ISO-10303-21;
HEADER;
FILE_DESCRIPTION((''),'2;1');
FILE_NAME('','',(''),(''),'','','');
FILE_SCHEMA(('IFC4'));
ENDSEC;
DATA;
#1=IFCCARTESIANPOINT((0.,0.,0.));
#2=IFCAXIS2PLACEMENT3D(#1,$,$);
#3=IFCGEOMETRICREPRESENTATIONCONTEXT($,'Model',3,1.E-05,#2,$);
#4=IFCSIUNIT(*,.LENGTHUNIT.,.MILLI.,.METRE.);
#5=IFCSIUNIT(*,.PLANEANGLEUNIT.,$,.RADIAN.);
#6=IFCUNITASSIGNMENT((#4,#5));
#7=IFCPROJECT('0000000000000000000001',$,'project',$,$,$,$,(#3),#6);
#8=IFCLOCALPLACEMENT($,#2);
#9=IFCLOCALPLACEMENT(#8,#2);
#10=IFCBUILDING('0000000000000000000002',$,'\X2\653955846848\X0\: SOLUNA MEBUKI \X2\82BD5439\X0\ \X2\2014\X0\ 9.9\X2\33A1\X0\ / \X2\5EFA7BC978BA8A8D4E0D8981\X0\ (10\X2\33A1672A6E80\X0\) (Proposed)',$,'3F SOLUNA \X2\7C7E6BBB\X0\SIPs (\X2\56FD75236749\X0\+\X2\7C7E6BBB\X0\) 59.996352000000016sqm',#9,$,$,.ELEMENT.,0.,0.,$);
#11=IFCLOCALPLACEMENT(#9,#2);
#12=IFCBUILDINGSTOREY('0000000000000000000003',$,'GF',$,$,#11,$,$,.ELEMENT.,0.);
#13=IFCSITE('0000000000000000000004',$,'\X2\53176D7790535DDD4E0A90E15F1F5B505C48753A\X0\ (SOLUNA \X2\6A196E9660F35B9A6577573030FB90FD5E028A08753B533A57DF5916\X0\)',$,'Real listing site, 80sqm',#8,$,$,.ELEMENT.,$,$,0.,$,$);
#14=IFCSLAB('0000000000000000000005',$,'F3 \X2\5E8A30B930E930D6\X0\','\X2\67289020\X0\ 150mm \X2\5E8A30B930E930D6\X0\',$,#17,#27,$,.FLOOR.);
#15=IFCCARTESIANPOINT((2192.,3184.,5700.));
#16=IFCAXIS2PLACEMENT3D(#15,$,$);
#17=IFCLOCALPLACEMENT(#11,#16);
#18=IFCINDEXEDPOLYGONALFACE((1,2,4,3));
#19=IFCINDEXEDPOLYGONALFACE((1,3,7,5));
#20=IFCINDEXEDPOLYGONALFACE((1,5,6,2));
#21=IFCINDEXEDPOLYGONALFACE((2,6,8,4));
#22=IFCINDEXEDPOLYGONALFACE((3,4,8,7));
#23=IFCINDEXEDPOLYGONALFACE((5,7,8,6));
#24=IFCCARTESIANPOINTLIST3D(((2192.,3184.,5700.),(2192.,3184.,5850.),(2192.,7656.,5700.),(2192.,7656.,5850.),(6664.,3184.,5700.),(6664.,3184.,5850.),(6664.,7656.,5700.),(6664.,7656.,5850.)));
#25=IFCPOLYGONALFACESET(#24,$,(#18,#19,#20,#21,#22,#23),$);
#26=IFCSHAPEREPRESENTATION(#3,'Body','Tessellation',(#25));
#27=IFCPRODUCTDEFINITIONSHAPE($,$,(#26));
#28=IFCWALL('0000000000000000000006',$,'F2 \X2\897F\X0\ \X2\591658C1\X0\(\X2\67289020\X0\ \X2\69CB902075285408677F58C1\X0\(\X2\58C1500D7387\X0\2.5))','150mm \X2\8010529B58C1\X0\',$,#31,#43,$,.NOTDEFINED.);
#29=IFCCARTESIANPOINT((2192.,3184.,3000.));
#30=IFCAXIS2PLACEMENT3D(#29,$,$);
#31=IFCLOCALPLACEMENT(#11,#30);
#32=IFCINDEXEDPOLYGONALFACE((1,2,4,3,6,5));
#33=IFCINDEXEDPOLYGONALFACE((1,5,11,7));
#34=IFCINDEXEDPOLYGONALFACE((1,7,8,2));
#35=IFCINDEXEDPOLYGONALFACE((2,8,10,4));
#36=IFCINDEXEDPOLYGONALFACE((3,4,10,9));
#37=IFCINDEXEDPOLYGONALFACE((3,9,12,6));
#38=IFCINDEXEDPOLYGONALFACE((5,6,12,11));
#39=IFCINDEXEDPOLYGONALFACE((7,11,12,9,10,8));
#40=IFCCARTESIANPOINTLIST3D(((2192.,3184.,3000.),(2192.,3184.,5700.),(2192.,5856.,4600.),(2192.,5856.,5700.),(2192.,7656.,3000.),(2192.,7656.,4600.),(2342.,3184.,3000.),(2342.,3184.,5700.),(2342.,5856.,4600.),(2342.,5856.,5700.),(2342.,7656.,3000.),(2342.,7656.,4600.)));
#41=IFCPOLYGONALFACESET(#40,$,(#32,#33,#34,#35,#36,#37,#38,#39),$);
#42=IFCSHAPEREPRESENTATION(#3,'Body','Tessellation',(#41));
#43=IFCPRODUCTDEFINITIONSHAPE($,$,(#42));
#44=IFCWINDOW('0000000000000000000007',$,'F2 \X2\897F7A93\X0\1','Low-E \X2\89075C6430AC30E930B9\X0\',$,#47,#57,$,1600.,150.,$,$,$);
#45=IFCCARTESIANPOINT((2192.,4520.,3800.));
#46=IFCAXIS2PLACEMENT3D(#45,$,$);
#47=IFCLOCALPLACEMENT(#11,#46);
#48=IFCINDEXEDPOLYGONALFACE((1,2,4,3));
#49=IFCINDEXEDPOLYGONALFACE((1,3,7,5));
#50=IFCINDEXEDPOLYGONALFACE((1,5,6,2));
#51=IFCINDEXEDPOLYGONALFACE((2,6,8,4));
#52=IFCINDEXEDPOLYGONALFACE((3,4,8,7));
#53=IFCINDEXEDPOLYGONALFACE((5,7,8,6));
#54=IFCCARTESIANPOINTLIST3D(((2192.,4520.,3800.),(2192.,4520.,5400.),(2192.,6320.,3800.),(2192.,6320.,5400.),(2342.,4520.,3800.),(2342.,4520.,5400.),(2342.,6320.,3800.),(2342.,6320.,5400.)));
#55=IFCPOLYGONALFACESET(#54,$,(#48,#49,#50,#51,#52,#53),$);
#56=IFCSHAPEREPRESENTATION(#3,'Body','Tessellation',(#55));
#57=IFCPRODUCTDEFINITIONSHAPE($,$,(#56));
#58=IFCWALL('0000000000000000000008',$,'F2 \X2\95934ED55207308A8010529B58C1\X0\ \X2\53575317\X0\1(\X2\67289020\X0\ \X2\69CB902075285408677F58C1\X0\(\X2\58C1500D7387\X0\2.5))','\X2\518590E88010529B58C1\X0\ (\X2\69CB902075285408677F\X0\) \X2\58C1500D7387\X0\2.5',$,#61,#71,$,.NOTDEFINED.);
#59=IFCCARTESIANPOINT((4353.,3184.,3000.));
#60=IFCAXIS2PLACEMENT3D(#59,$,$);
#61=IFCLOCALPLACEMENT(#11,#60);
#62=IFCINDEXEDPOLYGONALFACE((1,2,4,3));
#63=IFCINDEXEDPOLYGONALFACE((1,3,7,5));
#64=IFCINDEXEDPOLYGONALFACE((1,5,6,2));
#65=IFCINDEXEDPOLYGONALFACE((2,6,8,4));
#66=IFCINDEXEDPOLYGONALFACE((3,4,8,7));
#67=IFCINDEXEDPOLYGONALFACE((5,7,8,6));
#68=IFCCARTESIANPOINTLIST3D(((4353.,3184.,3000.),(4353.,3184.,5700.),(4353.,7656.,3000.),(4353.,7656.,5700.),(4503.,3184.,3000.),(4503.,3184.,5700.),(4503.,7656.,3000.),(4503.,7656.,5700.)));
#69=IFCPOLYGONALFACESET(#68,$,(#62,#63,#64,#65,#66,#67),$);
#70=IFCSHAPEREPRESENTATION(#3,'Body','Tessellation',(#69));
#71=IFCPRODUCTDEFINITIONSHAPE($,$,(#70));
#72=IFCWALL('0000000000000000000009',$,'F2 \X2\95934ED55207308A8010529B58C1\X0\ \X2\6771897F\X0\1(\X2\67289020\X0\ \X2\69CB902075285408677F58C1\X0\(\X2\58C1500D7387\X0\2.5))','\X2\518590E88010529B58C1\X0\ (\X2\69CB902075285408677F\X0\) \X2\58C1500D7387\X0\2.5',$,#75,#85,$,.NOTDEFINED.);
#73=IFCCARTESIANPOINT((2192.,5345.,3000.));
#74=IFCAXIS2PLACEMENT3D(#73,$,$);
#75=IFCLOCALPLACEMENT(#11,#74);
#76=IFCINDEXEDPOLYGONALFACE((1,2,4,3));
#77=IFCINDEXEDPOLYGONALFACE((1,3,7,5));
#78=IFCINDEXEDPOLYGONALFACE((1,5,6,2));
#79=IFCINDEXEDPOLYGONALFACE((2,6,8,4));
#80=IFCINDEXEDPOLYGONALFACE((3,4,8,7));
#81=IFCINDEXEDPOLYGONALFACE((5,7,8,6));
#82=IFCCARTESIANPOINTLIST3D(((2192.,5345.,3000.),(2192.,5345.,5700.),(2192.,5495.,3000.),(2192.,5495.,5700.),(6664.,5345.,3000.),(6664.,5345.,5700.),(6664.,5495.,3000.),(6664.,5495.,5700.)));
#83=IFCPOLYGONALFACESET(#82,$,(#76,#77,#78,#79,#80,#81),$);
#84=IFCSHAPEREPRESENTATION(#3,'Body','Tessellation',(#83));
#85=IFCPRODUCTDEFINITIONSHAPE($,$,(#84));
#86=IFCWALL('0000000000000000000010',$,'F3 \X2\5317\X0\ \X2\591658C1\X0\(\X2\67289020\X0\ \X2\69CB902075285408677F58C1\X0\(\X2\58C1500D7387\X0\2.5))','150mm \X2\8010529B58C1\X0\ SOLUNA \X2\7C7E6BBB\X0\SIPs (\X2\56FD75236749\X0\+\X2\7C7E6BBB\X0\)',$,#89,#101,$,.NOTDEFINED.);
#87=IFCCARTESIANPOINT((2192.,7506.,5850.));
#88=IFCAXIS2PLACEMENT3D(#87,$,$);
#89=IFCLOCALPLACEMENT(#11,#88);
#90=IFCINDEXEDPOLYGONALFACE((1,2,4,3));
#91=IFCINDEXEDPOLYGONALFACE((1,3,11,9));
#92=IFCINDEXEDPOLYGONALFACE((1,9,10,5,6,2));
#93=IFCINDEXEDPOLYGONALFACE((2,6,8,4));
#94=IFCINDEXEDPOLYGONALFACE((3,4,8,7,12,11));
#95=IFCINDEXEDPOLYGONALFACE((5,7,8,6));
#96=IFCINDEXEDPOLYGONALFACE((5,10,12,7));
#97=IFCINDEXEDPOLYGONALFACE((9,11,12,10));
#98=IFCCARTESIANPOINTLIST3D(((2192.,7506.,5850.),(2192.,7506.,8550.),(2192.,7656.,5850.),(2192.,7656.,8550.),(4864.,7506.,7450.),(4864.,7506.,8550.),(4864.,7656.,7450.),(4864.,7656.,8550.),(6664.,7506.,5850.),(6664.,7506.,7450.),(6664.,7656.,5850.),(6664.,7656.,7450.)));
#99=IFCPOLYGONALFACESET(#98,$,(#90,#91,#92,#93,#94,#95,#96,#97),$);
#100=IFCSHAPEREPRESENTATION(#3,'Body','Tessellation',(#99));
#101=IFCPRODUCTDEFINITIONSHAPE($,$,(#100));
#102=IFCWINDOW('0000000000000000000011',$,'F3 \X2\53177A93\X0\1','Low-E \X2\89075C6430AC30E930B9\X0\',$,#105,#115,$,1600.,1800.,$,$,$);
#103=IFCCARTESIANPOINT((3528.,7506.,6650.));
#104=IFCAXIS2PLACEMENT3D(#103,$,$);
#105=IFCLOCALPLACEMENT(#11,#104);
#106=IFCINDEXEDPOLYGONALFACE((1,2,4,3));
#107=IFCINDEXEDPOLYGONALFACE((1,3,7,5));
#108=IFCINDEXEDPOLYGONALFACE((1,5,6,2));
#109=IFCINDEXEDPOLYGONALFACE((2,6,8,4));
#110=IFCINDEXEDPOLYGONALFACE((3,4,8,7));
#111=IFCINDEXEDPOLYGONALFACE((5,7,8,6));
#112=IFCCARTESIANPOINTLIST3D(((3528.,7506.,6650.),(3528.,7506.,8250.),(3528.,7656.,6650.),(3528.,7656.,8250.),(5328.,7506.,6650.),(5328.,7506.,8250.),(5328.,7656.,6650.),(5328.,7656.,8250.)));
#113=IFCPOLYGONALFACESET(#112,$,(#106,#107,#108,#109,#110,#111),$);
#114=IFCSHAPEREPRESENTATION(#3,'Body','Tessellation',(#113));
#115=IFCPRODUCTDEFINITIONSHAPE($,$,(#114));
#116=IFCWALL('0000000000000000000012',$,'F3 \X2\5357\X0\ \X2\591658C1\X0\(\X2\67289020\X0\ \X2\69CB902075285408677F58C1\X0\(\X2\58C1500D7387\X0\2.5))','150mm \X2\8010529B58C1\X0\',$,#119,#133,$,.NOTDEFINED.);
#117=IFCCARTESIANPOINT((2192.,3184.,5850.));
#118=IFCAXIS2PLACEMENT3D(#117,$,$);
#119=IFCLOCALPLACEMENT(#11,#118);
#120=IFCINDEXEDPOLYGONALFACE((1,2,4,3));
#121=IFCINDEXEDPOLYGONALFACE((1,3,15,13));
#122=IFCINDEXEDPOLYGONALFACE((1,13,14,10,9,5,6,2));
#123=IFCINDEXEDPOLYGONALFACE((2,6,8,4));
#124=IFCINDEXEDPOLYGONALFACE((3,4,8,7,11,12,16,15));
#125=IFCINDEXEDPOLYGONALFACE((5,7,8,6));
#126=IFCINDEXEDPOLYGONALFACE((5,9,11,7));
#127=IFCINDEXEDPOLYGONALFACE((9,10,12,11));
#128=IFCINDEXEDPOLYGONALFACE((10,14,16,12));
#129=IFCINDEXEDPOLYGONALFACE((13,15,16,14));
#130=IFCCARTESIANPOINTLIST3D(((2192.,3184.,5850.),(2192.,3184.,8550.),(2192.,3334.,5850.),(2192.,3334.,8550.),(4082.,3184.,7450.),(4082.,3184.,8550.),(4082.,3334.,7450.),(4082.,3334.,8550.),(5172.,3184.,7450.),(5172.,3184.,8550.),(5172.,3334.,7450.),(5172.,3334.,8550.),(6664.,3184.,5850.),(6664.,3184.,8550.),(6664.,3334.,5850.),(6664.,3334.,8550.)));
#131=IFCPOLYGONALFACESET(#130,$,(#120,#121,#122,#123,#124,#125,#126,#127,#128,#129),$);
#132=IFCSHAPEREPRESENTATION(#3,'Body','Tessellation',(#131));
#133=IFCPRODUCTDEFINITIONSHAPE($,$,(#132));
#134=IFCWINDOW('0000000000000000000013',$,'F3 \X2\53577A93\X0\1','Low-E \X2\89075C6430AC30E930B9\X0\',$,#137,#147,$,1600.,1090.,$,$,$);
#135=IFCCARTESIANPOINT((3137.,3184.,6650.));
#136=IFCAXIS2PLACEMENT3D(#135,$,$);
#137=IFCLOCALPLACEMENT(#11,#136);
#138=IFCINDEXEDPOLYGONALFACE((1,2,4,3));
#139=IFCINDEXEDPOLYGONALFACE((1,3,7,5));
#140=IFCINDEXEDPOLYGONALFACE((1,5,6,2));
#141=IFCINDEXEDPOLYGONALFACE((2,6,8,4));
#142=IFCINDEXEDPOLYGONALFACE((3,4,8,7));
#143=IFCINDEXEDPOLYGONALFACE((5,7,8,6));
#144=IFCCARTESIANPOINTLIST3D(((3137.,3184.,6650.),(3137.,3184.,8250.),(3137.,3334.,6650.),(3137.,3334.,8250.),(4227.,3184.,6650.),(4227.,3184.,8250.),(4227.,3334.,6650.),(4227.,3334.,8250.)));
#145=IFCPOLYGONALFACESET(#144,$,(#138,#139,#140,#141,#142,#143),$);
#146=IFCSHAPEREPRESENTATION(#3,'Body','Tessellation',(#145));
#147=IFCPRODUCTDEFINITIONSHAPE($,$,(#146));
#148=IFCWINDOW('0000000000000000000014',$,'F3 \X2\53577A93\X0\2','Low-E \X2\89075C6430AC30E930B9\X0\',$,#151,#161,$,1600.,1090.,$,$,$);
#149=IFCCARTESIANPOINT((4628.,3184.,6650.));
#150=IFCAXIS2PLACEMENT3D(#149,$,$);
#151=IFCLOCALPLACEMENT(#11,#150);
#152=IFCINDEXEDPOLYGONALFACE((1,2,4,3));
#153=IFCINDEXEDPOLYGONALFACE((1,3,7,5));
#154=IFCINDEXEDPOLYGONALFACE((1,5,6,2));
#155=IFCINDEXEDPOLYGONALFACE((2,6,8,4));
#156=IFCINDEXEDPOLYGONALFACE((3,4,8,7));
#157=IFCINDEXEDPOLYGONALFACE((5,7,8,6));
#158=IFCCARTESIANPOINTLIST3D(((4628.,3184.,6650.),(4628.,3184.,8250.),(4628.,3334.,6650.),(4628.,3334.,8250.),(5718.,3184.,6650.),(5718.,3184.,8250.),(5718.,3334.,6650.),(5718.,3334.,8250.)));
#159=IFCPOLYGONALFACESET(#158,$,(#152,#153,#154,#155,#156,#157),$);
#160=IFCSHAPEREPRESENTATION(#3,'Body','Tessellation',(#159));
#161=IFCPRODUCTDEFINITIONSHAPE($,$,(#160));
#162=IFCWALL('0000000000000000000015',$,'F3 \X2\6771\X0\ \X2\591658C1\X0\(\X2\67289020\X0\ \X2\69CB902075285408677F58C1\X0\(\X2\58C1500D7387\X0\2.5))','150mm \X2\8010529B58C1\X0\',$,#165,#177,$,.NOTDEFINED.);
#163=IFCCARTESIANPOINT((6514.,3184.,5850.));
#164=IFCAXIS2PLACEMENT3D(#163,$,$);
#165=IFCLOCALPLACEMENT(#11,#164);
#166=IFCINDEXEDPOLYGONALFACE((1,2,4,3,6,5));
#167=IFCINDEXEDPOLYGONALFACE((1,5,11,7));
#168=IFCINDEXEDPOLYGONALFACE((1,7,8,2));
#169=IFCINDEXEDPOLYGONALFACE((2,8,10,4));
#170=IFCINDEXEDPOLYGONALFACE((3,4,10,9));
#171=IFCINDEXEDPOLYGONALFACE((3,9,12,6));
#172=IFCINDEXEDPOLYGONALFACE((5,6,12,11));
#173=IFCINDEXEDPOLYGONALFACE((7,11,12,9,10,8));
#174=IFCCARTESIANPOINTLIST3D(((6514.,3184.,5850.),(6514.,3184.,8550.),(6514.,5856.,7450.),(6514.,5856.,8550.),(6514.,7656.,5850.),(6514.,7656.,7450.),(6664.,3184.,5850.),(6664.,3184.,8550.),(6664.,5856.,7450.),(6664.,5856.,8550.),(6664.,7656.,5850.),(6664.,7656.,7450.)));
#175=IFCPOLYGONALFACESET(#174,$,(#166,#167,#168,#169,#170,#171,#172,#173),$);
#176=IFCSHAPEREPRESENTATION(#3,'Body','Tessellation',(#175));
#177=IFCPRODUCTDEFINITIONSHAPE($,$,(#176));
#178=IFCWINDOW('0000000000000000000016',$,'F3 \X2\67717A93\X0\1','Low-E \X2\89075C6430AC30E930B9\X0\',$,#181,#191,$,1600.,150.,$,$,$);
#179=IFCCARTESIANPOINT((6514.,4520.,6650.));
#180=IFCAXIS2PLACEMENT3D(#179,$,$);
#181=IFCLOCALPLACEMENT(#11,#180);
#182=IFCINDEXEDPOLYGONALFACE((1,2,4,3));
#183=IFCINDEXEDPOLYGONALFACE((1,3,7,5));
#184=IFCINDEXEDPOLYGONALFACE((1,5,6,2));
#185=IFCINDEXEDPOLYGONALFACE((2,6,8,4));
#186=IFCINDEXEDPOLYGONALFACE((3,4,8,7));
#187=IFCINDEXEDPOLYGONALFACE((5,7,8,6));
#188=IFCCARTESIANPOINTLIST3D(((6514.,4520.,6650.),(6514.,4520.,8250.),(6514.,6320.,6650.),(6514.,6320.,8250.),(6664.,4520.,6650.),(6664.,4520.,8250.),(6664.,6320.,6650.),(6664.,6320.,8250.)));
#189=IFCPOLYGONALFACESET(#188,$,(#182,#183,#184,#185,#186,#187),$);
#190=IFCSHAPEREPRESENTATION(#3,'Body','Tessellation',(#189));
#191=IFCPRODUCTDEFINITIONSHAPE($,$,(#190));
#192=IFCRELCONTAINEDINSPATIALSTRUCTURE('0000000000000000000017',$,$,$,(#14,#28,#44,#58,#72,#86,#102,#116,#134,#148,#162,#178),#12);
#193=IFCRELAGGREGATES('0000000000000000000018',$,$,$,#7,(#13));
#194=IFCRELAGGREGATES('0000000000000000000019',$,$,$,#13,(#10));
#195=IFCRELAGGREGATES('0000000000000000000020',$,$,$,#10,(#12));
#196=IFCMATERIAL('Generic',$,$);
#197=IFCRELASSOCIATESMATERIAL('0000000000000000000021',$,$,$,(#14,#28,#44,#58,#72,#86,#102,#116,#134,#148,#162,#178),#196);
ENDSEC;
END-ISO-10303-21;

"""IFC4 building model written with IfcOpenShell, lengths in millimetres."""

from ifc_helpers import new_model, si_unit, frame, frame_2d, origin, place, context, project, spatial, rectangle, extrude, material, element, fill, save


model = new_model("IFC4")

# Units and contexts
model_context = context("Model", 3, precision=1e-05, world=origin())
ifc_project = project(units=[si_unit("LENGTHUNIT", "METRE", prefix="MILLI"), si_unit("PLANEANGLEUNIT", "RADIAN")], contexts=[model_context])

# Site, building, storey
site_placement = place(None, origin())
site = spatial("IfcSite", under=ifc_project, at=site_placement, Name="北海道川上郡弟子屈町 (SOLUNA 標準想定敷地・都市計画区域外)", ObjectType="Real listing site, 80sqm", CompositionType="ELEMENT", RefElevation=0.0)
building_placement = place(site_placement, origin())
building = spatial("IfcBuilding", under=site, at=building_placement, Name="改善案: SOLUNA MEBUKI 芽吹 — 9.9㎡ / 建築確認不要 (10㎡未満) (Proposed)", ObjectType="3F SOLUNA 籾殻SIPs (国産杉+籾殻) 59.996352000000016sqm", CompositionType="ELEMENT", ElevationOfRefHeight=0.0, ElevationOfTerrain=0.0)
storey_placement = place(building_placement, origin())
storey = spatial("IfcBuildingStorey", under=building, at=storey_placement, Name="GF", CompositionType="ELEMENT", Elevation=0.0)

# Slab
ifc_material_1 = material(Name="Generic")
slab_placement = place(storey_placement, frame((2192.0, 3184.0, 5700.0)))
element("IfcSlab", 1, at=slab_placement, inside=storey, material=ifc_material_1, Name="F3 床スラブ", Description="木造 150mm 床スラブ", PredefinedType="FLOOR", context=model_context, shape_type="SweptSolid", body=[
    extrude(rectangle(XDim=4472.0, YDim=4472.0, at=frame_2d((2236.0, 2236.0))), frame((2192.0, 3184.0, 5700.0)), (0.0, 0.0, 1.0), 150.0),
])

# Wall, opening, window
wall_1_placement = place(storey_placement, frame((2192.0, 3184.0, 3000.0)))
wall_1 = element("IfcWall", 2, at=wall_1_placement, inside=storey, material=ifc_material_1, Name="F2 西 外壁(木造 構造用合板壁(壁倍率2.5))", Description="150mm 耐力壁", PredefinedType="NOTDEFINED", context=model_context, shape_type="SweptSolid", body=[
    extrude(rectangle(XDim=150.0, YDim=4472.0, at=frame_2d((75.0, 2236.0))), frame((2192.0, 3184.0, 3000.0)), (0.0, 0.0, 1.0), 2700.0),
])
opening_1_placement = place(storey_placement, frame((2192.0, 4520.0, 3800.0)))
opening_1 = element("IfcOpeningElement", 3, at=opening_1_placement, cuts=wall_1, PredefinedType="NOTDEFINED", context=model_context, shape_type="SweptSolid", body=[
    extrude(rectangle(XDim=150.0, YDim=1800.0, at=frame_2d((75.0, 900.0))), frame((2192.0, 4520.0, 3800.0)), (0.0, 0.0, 1.0), 1600.0),
])
window_1_placement = place(storey_placement, frame((2192.0, 4520.0, 3800.0)))
window_1 = element("IfcWindow", 4, at=window_1_placement, inside=storey, material=ifc_material_1, Name="F2 西窓1", Description="Low-E 複層ガラス", OverallHeight=1600.0, OverallWidth=150.0, context=model_context, shape_type="SweptSolid", body=[
    extrude(rectangle(XDim=150.0, YDim=1800.0, at=frame_2d((75.0, 900.0))), frame((2192.0, 4520.0, 3800.0)), (0.0, 0.0, 1.0), 1600.0),
])
fill(opening_1, window_1)

# Walls
wall_2_placement = place(storey_placement, frame((4353.0, 3184.0, 3000.0)))
element("IfcWall", 5, at=wall_2_placement, inside=storey, material=ifc_material_1, Name="F2 間仕切り耐力壁 南北1(木造 構造用合板壁(壁倍率2.5))", Description="内部耐力壁 (構造用合板) 壁倍率2.5", PredefinedType="NOTDEFINED", context=model_context, shape_type="SweptSolid", body=[
    extrude(rectangle(XDim=150.0, YDim=4472.0, at=frame_2d((75.0, 2236.0))), frame((4353.0, 3184.0, 3000.0)), (0.0, 0.0, 1.0), 2700.0),
])
wall_3_placement = place(storey_placement, frame((2192.0, 5345.0, 3000.0)))
element("IfcWall", 6, at=wall_3_placement, inside=storey, material=ifc_material_1, Name="F2 間仕切り耐力壁 東西1(木造 構造用合板壁(壁倍率2.5))", Description="内部耐力壁 (構造用合板) 壁倍率2.5", PredefinedType="NOTDEFINED", context=model_context, shape_type="SweptSolid", body=[
    extrude(rectangle(XDim=4472.0, YDim=150.0, at=frame_2d((2236.0, 75.0))), frame((2192.0, 5345.0, 3000.0)), (0.0, 0.0, 1.0), 2700.0),
])

# Wall, opening, window
wall_4_placement = place(storey_placement, frame((2192.0, 7506.0, 5850.0)))
wall_4 = element("IfcWall", 7, at=wall_4_placement, inside=storey, material=ifc_material_1, Name="F3 北 外壁(木造 構造用合板壁(壁倍率2.5))", Description="150mm 耐力壁 SOLUNA 籾殻SIPs (国産杉+籾殻)", PredefinedType="NOTDEFINED", context=model_context, shape_type="SweptSolid", body=[
    extrude(rectangle(XDim=4472.0, YDim=150.0, at=frame_2d((2236.0, 75.0))), frame((2192.0, 7506.0, 5850.0)), (0.0, 0.0, 1.0), 2700.0),
])
opening_2_placement = place(storey_placement, frame((3528.0, 7506.0, 6650.0)))
opening_2 = element("IfcOpeningElement", 8, at=opening_2_placement, cuts=wall_4, PredefinedType="NOTDEFINED", context=model_context, shape_type="SweptSolid", body=[
    extrude(rectangle(XDim=1800.0, YDim=150.0, at=frame_2d((900.0, 75.0))), frame((3528.0, 7506.0, 6650.0)), (0.0, 0.0, 1.0), 1600.0),
])
window_2_placement = place(storey_placement, frame((3528.0, 7506.0, 6650.0)))
window_2 = element("IfcWindow", 9, at=window_2_placement, inside=storey, material=ifc_material_1, Name="F3 北窓1", Description="Low-E 複層ガラス", OverallHeight=1600.0, OverallWidth=1800.0, context=model_context, shape_type="SweptSolid", body=[
    extrude(rectangle(XDim=1800.0, YDim=150.0, at=frame_2d((900.0, 75.0))), frame((3528.0, 7506.0, 6650.0)), (0.0, 0.0, 1.0), 1600.0),
])
fill(opening_2, window_2)

# Wall, openings, windows
wall_5_placement = place(storey_placement, frame((2192.0, 3184.0, 5850.0)))
wall_5 = element("IfcWall", 10, at=wall_5_placement, inside=storey, material=ifc_material_1, Name="F3 南 外壁(木造 構造用合板壁(壁倍率2.5))", Description="150mm 耐力壁", PredefinedType="NOTDEFINED", context=model_context, shape_type="SweptSolid", body=[
    extrude(rectangle(XDim=4472.0, YDim=150.0, at=frame_2d((2236.0, 75.0))), frame((2192.0, 3184.0, 5850.0)), (0.0, 0.0, 1.0), 2700.0),
])
opening_3_placement = place(storey_placement, frame((3137.0, 3184.0, 6650.0)))
opening_3 = element("IfcOpeningElement", 11, at=opening_3_placement, cuts=wall_5, PredefinedType="NOTDEFINED", context=model_context, shape_type="SweptSolid", body=[
    extrude(rectangle(XDim=1090.0, YDim=150.0, at=frame_2d((545.0, 75.0))), frame((3137.0, 3184.0, 6650.0)), (0.0, 0.0, 1.0), 1600.0),
])
opening_4_placement = place(storey_placement, frame((4628.0, 3184.0, 6650.0)))
opening_4 = element("IfcOpeningElement", 12, at=opening_4_placement, cuts=wall_5, PredefinedType="NOTDEFINED", context=model_context, shape_type="SweptSolid", body=[
    extrude(rectangle(XDim=1090.0, YDim=150.0, at=frame_2d((545.0, 75.0))), frame((4628.0, 3184.0, 6650.0)), (0.0, 0.0, 1.0), 1600.0),
])
window_3_placement = place(storey_placement, frame((3137.0, 3184.0, 6650.0)))
window_3 = element("IfcWindow", 13, at=window_3_placement, inside=storey, material=ifc_material_1, Name="F3 南窓1", Description="Low-E 複層ガラス", OverallHeight=1600.0, OverallWidth=1090.0, context=model_context, shape_type="SweptSolid", body=[
    extrude(rectangle(XDim=1090.0, YDim=150.0, at=frame_2d((545.0, 75.0))), frame((3137.0, 3184.0, 6650.0)), (0.0, 0.0, 1.0), 1600.0),
])
fill(opening_3, window_3)
window_4_placement = place(storey_placement, frame((4628.0, 3184.0, 6650.0)))
window_4 = element("IfcWindow", 14, at=window_4_placement, inside=storey, material=ifc_material_1, Name="F3 南窓2", Description="Low-E 複層ガラス", OverallHeight=1600.0, OverallWidth=1090.0, context=model_context, shape_type="SweptSolid", body=[
    extrude(rectangle(XDim=1090.0, YDim=150.0, at=frame_2d((545.0, 75.0))), frame((4628.0, 3184.0, 6650.0)), (0.0, 0.0, 1.0), 1600.0),
])
fill(opening_4, window_4)

# Wall, opening, window
wall_6_placement = place(storey_placement, frame((6514.0, 3184.0, 5850.0)))
wall_6 = element("IfcWall", 15, at=wall_6_placement, inside=storey, material=ifc_material_1, Name="F3 東 外壁(木造 構造用合板壁(壁倍率2.5))", Description="150mm 耐力壁", PredefinedType="NOTDEFINED", context=model_context, shape_type="SweptSolid", body=[
    extrude(rectangle(XDim=150.0, YDim=4472.0, at=frame_2d((75.0, 2236.0))), frame((6514.0, 3184.0, 5850.0)), (0.0, 0.0, 1.0), 2700.0),
])
opening_5_placement = place(storey_placement, frame((6514.0, 4520.0, 6650.0)))
opening_5 = element("IfcOpeningElement", 16, at=opening_5_placement, cuts=wall_6, PredefinedType="NOTDEFINED", context=model_context, shape_type="SweptSolid", body=[
    extrude(rectangle(XDim=150.0, YDim=1800.0, at=frame_2d((75.0, 900.0))), frame((6514.0, 4520.0, 6650.0)), (0.0, 0.0, 1.0), 1600.0),
])
window_5_placement = place(storey_placement, frame((6514.0, 4520.0, 6650.0)))
window_5 = element("IfcWindow", 17, at=window_5_placement, inside=storey, material=ifc_material_1, Name="F3 東窓1", Description="Low-E 複層ガラス", OverallHeight=1600.0, OverallWidth=150.0, context=model_context, shape_type="SweptSolid", body=[
    extrude(rectangle(XDim=150.0, YDim=1800.0, at=frame_2d((75.0, 900.0))), frame((6514.0, 4520.0, 6650.0)), (0.0, 0.0, 1.0), 1600.0),
])
fill(opening_5, window_5)

save(model, "model.ifc")
